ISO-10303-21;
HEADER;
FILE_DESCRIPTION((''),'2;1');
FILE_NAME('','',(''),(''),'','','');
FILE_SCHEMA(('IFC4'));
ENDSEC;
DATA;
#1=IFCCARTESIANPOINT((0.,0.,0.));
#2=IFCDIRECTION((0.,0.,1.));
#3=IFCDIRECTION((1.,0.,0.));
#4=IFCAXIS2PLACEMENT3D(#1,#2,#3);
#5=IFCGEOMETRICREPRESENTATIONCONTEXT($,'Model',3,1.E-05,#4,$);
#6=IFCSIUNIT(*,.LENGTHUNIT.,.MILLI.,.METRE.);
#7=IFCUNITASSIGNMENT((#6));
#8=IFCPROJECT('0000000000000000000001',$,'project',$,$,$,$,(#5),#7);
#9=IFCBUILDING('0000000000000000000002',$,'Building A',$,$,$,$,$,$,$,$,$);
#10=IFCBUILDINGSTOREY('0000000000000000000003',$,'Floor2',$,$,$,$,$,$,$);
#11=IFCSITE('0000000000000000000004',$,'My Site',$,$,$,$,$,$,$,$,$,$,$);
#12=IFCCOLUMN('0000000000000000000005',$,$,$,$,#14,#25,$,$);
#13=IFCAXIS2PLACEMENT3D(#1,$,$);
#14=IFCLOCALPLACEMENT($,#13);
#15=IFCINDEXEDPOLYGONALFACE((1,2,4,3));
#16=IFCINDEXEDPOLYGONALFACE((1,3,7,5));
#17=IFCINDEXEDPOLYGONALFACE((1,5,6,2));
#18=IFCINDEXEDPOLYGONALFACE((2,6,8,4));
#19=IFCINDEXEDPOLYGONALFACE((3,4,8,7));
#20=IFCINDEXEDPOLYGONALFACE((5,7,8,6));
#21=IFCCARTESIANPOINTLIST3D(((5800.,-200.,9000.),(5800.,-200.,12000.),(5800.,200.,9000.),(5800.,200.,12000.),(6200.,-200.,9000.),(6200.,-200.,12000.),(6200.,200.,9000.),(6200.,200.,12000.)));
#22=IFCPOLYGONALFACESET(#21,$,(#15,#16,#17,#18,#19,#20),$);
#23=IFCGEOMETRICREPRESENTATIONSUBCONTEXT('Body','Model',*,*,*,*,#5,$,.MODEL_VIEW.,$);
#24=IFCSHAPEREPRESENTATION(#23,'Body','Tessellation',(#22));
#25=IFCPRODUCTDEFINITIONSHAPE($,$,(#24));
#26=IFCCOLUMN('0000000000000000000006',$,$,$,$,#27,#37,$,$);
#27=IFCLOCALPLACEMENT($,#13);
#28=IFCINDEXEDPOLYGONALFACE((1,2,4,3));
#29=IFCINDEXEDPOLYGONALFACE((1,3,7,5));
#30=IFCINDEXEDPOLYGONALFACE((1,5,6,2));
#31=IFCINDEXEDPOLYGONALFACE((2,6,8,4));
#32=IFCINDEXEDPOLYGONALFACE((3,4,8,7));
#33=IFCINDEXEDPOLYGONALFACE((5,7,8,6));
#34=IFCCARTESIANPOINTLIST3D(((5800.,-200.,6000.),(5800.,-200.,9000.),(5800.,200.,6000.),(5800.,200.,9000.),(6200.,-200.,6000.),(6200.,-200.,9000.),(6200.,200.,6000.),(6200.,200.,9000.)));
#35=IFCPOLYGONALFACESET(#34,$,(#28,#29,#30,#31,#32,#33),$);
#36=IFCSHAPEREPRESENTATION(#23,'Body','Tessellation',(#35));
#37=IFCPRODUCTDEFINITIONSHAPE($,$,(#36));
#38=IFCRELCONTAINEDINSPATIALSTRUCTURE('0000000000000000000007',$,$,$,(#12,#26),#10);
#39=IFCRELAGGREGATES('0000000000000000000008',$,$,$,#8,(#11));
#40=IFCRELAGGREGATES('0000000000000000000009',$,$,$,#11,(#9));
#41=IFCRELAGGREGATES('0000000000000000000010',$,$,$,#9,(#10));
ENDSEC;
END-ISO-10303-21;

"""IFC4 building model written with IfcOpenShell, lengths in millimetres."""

from ifc_helpers import new_model, si_unit, frame, origin_with_axes, place, context, subcontext, project, spatial, line, indexed_curve, outline, extrude, element, save


model = new_model("IFC4")

# Units and contexts
model_context = context("Model", 3, precision=1e-05, world=origin_with_axes())
body_context = subcontext(model_context, "Body", "Model", "MODEL_VIEW")
ifc_project = project(units=[si_unit("LENGTHUNIT", "METRE", prefix="MILLI")], contexts=[model_context])

# Site, building, storey
site = spatial("IfcSite", under=ifc_project, Name="My Site")
building = spatial("IfcBuilding", under=site, Name="Building A")
storey = spatial("IfcBuildingStorey", under=building, Name="Floor2")

# Columns
for number, where, z_axis, x_axis in (
    (1, (6000.0, 0.0, 9000.0), (0.0, 0.0, 1.0), (1.0, 0.0, 0.0)),
    (2, (6000.0, 0.0, 6000.0), (0.0, 0.0, 1.0), (1.0, 0.0, 0.0)),
):
    element("IfcColumn", number, at=place(None, frame(where, z_axis=z_axis, x_axis=x_axis)), inside=storey, context=body_context, shape_type="SweptSolid", body=[
        extrude(outline(indexed_curve([(-200.0, -200.0), (200.0, -200.0), (200.0, 200.0), (-200.0, 200.0)], segments=[line(1, 2, 3, 4, 1)])), origin_with_axes(), (0.0, 0.0, 1.0), 3000.0),
    ])

save(model, "model.ifc")
